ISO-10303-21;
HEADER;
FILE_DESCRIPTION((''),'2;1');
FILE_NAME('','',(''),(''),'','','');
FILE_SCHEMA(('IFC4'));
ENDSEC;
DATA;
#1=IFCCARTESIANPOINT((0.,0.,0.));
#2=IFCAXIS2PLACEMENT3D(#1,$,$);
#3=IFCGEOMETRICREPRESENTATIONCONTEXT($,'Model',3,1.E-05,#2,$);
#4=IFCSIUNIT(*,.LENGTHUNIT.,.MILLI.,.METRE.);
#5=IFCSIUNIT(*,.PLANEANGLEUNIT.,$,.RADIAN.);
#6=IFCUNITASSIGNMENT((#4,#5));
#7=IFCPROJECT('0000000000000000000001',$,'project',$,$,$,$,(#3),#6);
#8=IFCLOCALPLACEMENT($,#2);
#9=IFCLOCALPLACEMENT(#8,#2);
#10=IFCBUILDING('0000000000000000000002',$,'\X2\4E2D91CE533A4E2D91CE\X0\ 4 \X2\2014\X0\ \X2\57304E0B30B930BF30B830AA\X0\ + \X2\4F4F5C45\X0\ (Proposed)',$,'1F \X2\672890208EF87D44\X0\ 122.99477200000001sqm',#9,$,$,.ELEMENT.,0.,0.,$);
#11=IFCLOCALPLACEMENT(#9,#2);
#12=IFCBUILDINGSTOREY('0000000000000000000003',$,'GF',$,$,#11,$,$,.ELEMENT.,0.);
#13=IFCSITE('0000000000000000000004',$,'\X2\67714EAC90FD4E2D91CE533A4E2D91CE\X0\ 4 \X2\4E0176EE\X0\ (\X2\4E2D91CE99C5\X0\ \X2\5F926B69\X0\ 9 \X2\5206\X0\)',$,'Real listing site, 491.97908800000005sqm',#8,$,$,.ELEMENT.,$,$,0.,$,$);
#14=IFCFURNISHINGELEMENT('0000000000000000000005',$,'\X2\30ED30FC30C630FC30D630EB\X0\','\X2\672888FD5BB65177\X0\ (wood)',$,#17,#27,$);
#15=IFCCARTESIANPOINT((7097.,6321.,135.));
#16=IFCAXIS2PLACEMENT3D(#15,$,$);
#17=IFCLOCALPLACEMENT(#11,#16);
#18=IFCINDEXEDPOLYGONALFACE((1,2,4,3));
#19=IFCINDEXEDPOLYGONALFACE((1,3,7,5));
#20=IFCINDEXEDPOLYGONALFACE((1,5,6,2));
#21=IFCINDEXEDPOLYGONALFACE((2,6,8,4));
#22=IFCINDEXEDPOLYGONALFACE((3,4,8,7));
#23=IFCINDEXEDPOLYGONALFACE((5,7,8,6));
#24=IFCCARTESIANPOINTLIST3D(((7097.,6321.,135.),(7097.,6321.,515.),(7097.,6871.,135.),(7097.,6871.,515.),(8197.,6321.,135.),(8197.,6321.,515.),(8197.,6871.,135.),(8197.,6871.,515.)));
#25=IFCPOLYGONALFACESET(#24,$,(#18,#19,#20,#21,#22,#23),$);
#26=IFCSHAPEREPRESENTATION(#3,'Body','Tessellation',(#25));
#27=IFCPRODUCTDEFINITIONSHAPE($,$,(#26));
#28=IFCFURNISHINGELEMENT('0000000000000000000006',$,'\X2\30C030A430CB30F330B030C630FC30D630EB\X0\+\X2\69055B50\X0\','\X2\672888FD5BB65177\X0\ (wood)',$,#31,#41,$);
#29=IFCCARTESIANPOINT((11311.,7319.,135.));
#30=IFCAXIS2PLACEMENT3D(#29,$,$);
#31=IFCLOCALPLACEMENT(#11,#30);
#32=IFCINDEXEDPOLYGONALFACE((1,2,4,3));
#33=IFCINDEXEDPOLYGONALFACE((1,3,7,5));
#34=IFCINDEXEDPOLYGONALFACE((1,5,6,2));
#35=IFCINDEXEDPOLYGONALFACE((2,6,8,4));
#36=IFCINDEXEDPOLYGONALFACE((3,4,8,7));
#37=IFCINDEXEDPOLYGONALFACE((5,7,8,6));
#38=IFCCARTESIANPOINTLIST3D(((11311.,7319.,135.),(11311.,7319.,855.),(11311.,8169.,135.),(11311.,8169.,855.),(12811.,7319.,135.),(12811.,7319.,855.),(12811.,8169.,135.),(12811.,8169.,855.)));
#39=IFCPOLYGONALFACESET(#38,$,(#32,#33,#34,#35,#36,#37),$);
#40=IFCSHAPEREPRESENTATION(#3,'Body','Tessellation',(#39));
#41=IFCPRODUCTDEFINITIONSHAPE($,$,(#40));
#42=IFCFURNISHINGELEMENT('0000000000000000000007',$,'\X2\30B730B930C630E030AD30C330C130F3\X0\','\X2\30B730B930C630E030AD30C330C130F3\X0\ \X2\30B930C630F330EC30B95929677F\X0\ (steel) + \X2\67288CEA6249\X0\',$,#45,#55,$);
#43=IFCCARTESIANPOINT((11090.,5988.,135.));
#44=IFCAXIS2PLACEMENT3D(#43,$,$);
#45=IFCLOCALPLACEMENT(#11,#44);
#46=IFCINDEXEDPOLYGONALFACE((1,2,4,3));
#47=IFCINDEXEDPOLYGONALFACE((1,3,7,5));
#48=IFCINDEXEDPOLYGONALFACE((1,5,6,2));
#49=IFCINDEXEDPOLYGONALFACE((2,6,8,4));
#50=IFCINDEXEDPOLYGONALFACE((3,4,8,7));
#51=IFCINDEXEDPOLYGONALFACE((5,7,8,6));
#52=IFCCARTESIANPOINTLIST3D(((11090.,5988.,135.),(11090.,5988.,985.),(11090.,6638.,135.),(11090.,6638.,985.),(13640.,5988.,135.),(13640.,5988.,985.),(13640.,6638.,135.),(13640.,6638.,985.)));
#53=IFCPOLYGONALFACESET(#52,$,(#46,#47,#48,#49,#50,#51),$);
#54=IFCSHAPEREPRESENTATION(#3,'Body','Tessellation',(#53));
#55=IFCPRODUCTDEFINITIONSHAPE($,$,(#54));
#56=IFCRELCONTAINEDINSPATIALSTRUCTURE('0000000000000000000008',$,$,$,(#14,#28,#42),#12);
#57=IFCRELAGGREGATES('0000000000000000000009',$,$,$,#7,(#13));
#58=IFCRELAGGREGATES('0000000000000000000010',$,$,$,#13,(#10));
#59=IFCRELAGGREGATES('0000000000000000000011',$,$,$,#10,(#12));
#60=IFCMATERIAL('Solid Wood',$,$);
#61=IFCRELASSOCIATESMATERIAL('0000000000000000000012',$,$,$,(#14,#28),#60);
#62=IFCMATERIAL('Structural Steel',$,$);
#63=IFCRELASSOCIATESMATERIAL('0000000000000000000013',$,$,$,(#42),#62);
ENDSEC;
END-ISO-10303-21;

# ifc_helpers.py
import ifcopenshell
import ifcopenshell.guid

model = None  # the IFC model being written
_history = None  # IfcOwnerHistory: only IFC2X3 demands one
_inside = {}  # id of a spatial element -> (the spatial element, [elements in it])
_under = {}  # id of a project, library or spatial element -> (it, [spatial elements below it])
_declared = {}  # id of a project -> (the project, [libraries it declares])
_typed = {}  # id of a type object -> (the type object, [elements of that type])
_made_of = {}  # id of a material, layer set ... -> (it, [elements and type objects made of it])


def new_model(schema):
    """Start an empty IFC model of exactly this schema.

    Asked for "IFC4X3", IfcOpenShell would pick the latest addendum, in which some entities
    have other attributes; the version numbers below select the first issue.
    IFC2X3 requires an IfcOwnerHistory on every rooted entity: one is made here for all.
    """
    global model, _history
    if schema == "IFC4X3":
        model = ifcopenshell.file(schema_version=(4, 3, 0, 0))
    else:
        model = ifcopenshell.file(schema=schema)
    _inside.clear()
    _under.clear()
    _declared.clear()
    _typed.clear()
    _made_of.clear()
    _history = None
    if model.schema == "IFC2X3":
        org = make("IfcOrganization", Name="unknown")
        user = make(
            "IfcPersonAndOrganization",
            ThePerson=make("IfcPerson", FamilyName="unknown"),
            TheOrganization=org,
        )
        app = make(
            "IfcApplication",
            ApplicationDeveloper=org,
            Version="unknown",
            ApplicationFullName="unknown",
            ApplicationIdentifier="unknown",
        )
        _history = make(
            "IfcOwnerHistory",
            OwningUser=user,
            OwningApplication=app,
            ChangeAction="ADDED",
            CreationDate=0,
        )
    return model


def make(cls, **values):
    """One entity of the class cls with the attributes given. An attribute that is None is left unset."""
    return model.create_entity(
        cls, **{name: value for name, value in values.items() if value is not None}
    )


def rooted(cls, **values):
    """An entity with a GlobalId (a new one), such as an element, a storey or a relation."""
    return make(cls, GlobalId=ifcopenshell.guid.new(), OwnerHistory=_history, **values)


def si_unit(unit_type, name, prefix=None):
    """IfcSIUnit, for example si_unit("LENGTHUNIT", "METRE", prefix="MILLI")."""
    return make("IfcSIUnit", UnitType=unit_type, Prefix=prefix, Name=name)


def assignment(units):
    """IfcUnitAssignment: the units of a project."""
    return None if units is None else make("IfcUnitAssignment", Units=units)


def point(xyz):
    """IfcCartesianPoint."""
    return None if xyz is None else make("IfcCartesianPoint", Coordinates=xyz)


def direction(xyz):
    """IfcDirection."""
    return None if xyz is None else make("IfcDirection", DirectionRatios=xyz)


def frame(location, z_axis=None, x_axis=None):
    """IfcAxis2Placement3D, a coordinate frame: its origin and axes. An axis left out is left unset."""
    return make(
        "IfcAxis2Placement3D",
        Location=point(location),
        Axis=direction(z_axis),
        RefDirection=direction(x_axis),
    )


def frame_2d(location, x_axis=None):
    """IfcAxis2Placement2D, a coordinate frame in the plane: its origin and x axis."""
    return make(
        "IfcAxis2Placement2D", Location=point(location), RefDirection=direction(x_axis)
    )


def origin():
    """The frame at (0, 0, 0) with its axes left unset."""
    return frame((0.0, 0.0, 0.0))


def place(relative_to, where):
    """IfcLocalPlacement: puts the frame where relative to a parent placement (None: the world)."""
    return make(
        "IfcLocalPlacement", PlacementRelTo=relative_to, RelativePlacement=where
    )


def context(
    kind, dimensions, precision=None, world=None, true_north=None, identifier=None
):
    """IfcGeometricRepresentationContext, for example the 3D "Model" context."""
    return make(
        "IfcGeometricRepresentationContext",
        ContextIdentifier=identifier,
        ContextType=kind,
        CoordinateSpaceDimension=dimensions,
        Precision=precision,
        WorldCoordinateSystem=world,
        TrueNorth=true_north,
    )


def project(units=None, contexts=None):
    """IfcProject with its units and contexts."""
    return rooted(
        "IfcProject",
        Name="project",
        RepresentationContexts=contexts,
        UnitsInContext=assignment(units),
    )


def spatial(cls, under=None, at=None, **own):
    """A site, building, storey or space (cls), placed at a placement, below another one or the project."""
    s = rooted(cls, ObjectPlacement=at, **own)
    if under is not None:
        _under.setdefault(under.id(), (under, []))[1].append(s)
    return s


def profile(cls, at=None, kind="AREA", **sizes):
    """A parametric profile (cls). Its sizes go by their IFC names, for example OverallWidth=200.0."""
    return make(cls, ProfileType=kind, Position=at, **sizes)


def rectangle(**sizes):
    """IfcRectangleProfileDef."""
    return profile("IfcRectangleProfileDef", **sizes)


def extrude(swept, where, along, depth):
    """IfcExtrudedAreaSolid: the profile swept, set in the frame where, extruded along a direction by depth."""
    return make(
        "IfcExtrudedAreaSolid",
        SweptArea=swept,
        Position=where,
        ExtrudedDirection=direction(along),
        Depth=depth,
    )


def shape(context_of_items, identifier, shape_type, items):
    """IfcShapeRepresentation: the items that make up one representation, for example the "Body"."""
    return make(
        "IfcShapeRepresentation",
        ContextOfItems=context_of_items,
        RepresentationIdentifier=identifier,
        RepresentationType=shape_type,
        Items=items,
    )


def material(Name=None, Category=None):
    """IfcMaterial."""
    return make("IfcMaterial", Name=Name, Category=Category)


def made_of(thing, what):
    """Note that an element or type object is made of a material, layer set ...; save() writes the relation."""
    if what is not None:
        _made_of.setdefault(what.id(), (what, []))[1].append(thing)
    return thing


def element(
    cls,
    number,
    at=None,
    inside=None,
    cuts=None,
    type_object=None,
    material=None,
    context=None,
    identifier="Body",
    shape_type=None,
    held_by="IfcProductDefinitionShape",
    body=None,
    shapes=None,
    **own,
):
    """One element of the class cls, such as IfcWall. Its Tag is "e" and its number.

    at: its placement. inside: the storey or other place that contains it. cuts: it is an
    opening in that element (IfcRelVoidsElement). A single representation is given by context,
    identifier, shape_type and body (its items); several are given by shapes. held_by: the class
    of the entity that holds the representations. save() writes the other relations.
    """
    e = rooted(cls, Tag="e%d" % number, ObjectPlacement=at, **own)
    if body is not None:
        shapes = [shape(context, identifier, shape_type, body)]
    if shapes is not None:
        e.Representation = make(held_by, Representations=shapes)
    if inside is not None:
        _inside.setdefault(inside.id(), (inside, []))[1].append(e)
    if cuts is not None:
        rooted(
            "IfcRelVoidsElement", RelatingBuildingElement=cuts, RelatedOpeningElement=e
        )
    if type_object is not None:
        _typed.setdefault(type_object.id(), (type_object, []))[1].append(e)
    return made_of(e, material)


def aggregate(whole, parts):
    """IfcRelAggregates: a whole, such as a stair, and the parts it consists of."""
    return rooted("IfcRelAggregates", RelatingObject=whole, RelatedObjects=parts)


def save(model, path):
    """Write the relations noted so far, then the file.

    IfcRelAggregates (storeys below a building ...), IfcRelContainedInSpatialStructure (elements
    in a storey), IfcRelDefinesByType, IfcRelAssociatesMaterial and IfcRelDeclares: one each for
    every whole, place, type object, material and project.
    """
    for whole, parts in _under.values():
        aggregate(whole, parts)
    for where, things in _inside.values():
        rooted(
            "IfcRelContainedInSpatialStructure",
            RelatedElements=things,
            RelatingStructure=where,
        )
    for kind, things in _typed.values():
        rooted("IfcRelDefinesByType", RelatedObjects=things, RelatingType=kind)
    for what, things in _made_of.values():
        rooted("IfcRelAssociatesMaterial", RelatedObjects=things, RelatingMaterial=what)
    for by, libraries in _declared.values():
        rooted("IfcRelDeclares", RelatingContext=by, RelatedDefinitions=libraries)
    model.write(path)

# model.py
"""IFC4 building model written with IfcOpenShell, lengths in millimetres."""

from ifc_helpers import new_model, si_unit, frame, frame_2d, origin, place, context, project, spatial, rectangle, extrude, material, element, save


model = new_model("IFC4")

# Units and contexts
model_context = context("Model", 3, precision=1e-05, world=origin())
ifc_project = project(units=[si_unit("LENGTHUNIT", "METRE", prefix="MILLI"), si_unit("PLANEANGLEUNIT", "RADIAN")], contexts=[model_context])

# Site, building, storey
site_placement = place(None, origin())
site = spatial("IfcSite", under=ifc_project, at=site_placement, Name="東京都中野区中野 4 丁目 (中野駅 徒歩 9 分)", ObjectType="Real listing site, 491.97908800000005sqm", CompositionType="ELEMENT", RefElevation=0.0)
building_placement = place(site_placement, origin())
building = spatial("IfcBuilding", under=site, at=building_placement, Name="中野区中野 4 — 地下スタジオ + 住居 (Proposed)", ObjectType="1F 木造軸組 122.99477200000001sqm", CompositionType="ELEMENT", ElevationOfRefHeight=0.0, ElevationOfTerrain=0.0)
storey_placement = place(building_placement, origin())
storey = spatial("IfcBuildingStorey", under=building, at=storey_placement, Name="GF", CompositionType="ELEMENT", Elevation=0.0)

# Shared definitions
ifc_material_1 = material(Name="Solid Wood")

# Shared definitions
ifc_material_2 = material(Name="Structural Steel")

# Furnishing elements
furnishing_1_placement = place(storey_placement, frame((7097.0, 6321.0, 135.0)))
element("IfcFurnishingElement", 1, at=furnishing_1_placement, inside=storey, material=ifc_material_1, Name="ローテーブル", Description="木製家具 (wood)", context=model_context, shape_type="SweptSolid", body=[
    extrude(rectangle(XDim=1100.0, YDim=550.0, at=frame_2d((550.0, 275.0))), frame((7097.0, 6321.0, 135.0)), (0.0, 0.0, 1.0), 380.0),
])
furnishing_2_placement = place(storey_placement, frame((11311.0, 7319.0, 135.0)))
element("IfcFurnishingElement", 2, at=furnishing_2_placement, inside=storey, material=ifc_material_1, Name="ダイニングテーブル+椅子", Description="木製家具 (wood)", context=model_context, shape_type="SweptSolid", body=[
    extrude(rectangle(XDim=1500.0, YDim=850.0, at=frame_2d((750.0, 425.0))), frame((11311.0, 7319.0, 135.0)), (0.0, 0.0, 1.0), 720.0),
])
furnishing_3_placement = place(storey_placement, frame((11090.0, 5988.0, 135.0)))
element("IfcFurnishingElement", 3, at=furnishing_3_placement, inside=storey, material=ifc_material_2, Name="システムキッチン", Description="システムキッチン ステンレス天板 (steel) + 木質扉", context=model_context, shape_type="SweptSolid", body=[
    extrude(rectangle(XDim=2550.0, YDim=650.0, at=frame_2d((1275.0, 325.0))), frame((11090.0, 5988.0, 135.0)), (0.0, 0.0, 1.0), 850.0),
])

save(model, "model.ifc")
